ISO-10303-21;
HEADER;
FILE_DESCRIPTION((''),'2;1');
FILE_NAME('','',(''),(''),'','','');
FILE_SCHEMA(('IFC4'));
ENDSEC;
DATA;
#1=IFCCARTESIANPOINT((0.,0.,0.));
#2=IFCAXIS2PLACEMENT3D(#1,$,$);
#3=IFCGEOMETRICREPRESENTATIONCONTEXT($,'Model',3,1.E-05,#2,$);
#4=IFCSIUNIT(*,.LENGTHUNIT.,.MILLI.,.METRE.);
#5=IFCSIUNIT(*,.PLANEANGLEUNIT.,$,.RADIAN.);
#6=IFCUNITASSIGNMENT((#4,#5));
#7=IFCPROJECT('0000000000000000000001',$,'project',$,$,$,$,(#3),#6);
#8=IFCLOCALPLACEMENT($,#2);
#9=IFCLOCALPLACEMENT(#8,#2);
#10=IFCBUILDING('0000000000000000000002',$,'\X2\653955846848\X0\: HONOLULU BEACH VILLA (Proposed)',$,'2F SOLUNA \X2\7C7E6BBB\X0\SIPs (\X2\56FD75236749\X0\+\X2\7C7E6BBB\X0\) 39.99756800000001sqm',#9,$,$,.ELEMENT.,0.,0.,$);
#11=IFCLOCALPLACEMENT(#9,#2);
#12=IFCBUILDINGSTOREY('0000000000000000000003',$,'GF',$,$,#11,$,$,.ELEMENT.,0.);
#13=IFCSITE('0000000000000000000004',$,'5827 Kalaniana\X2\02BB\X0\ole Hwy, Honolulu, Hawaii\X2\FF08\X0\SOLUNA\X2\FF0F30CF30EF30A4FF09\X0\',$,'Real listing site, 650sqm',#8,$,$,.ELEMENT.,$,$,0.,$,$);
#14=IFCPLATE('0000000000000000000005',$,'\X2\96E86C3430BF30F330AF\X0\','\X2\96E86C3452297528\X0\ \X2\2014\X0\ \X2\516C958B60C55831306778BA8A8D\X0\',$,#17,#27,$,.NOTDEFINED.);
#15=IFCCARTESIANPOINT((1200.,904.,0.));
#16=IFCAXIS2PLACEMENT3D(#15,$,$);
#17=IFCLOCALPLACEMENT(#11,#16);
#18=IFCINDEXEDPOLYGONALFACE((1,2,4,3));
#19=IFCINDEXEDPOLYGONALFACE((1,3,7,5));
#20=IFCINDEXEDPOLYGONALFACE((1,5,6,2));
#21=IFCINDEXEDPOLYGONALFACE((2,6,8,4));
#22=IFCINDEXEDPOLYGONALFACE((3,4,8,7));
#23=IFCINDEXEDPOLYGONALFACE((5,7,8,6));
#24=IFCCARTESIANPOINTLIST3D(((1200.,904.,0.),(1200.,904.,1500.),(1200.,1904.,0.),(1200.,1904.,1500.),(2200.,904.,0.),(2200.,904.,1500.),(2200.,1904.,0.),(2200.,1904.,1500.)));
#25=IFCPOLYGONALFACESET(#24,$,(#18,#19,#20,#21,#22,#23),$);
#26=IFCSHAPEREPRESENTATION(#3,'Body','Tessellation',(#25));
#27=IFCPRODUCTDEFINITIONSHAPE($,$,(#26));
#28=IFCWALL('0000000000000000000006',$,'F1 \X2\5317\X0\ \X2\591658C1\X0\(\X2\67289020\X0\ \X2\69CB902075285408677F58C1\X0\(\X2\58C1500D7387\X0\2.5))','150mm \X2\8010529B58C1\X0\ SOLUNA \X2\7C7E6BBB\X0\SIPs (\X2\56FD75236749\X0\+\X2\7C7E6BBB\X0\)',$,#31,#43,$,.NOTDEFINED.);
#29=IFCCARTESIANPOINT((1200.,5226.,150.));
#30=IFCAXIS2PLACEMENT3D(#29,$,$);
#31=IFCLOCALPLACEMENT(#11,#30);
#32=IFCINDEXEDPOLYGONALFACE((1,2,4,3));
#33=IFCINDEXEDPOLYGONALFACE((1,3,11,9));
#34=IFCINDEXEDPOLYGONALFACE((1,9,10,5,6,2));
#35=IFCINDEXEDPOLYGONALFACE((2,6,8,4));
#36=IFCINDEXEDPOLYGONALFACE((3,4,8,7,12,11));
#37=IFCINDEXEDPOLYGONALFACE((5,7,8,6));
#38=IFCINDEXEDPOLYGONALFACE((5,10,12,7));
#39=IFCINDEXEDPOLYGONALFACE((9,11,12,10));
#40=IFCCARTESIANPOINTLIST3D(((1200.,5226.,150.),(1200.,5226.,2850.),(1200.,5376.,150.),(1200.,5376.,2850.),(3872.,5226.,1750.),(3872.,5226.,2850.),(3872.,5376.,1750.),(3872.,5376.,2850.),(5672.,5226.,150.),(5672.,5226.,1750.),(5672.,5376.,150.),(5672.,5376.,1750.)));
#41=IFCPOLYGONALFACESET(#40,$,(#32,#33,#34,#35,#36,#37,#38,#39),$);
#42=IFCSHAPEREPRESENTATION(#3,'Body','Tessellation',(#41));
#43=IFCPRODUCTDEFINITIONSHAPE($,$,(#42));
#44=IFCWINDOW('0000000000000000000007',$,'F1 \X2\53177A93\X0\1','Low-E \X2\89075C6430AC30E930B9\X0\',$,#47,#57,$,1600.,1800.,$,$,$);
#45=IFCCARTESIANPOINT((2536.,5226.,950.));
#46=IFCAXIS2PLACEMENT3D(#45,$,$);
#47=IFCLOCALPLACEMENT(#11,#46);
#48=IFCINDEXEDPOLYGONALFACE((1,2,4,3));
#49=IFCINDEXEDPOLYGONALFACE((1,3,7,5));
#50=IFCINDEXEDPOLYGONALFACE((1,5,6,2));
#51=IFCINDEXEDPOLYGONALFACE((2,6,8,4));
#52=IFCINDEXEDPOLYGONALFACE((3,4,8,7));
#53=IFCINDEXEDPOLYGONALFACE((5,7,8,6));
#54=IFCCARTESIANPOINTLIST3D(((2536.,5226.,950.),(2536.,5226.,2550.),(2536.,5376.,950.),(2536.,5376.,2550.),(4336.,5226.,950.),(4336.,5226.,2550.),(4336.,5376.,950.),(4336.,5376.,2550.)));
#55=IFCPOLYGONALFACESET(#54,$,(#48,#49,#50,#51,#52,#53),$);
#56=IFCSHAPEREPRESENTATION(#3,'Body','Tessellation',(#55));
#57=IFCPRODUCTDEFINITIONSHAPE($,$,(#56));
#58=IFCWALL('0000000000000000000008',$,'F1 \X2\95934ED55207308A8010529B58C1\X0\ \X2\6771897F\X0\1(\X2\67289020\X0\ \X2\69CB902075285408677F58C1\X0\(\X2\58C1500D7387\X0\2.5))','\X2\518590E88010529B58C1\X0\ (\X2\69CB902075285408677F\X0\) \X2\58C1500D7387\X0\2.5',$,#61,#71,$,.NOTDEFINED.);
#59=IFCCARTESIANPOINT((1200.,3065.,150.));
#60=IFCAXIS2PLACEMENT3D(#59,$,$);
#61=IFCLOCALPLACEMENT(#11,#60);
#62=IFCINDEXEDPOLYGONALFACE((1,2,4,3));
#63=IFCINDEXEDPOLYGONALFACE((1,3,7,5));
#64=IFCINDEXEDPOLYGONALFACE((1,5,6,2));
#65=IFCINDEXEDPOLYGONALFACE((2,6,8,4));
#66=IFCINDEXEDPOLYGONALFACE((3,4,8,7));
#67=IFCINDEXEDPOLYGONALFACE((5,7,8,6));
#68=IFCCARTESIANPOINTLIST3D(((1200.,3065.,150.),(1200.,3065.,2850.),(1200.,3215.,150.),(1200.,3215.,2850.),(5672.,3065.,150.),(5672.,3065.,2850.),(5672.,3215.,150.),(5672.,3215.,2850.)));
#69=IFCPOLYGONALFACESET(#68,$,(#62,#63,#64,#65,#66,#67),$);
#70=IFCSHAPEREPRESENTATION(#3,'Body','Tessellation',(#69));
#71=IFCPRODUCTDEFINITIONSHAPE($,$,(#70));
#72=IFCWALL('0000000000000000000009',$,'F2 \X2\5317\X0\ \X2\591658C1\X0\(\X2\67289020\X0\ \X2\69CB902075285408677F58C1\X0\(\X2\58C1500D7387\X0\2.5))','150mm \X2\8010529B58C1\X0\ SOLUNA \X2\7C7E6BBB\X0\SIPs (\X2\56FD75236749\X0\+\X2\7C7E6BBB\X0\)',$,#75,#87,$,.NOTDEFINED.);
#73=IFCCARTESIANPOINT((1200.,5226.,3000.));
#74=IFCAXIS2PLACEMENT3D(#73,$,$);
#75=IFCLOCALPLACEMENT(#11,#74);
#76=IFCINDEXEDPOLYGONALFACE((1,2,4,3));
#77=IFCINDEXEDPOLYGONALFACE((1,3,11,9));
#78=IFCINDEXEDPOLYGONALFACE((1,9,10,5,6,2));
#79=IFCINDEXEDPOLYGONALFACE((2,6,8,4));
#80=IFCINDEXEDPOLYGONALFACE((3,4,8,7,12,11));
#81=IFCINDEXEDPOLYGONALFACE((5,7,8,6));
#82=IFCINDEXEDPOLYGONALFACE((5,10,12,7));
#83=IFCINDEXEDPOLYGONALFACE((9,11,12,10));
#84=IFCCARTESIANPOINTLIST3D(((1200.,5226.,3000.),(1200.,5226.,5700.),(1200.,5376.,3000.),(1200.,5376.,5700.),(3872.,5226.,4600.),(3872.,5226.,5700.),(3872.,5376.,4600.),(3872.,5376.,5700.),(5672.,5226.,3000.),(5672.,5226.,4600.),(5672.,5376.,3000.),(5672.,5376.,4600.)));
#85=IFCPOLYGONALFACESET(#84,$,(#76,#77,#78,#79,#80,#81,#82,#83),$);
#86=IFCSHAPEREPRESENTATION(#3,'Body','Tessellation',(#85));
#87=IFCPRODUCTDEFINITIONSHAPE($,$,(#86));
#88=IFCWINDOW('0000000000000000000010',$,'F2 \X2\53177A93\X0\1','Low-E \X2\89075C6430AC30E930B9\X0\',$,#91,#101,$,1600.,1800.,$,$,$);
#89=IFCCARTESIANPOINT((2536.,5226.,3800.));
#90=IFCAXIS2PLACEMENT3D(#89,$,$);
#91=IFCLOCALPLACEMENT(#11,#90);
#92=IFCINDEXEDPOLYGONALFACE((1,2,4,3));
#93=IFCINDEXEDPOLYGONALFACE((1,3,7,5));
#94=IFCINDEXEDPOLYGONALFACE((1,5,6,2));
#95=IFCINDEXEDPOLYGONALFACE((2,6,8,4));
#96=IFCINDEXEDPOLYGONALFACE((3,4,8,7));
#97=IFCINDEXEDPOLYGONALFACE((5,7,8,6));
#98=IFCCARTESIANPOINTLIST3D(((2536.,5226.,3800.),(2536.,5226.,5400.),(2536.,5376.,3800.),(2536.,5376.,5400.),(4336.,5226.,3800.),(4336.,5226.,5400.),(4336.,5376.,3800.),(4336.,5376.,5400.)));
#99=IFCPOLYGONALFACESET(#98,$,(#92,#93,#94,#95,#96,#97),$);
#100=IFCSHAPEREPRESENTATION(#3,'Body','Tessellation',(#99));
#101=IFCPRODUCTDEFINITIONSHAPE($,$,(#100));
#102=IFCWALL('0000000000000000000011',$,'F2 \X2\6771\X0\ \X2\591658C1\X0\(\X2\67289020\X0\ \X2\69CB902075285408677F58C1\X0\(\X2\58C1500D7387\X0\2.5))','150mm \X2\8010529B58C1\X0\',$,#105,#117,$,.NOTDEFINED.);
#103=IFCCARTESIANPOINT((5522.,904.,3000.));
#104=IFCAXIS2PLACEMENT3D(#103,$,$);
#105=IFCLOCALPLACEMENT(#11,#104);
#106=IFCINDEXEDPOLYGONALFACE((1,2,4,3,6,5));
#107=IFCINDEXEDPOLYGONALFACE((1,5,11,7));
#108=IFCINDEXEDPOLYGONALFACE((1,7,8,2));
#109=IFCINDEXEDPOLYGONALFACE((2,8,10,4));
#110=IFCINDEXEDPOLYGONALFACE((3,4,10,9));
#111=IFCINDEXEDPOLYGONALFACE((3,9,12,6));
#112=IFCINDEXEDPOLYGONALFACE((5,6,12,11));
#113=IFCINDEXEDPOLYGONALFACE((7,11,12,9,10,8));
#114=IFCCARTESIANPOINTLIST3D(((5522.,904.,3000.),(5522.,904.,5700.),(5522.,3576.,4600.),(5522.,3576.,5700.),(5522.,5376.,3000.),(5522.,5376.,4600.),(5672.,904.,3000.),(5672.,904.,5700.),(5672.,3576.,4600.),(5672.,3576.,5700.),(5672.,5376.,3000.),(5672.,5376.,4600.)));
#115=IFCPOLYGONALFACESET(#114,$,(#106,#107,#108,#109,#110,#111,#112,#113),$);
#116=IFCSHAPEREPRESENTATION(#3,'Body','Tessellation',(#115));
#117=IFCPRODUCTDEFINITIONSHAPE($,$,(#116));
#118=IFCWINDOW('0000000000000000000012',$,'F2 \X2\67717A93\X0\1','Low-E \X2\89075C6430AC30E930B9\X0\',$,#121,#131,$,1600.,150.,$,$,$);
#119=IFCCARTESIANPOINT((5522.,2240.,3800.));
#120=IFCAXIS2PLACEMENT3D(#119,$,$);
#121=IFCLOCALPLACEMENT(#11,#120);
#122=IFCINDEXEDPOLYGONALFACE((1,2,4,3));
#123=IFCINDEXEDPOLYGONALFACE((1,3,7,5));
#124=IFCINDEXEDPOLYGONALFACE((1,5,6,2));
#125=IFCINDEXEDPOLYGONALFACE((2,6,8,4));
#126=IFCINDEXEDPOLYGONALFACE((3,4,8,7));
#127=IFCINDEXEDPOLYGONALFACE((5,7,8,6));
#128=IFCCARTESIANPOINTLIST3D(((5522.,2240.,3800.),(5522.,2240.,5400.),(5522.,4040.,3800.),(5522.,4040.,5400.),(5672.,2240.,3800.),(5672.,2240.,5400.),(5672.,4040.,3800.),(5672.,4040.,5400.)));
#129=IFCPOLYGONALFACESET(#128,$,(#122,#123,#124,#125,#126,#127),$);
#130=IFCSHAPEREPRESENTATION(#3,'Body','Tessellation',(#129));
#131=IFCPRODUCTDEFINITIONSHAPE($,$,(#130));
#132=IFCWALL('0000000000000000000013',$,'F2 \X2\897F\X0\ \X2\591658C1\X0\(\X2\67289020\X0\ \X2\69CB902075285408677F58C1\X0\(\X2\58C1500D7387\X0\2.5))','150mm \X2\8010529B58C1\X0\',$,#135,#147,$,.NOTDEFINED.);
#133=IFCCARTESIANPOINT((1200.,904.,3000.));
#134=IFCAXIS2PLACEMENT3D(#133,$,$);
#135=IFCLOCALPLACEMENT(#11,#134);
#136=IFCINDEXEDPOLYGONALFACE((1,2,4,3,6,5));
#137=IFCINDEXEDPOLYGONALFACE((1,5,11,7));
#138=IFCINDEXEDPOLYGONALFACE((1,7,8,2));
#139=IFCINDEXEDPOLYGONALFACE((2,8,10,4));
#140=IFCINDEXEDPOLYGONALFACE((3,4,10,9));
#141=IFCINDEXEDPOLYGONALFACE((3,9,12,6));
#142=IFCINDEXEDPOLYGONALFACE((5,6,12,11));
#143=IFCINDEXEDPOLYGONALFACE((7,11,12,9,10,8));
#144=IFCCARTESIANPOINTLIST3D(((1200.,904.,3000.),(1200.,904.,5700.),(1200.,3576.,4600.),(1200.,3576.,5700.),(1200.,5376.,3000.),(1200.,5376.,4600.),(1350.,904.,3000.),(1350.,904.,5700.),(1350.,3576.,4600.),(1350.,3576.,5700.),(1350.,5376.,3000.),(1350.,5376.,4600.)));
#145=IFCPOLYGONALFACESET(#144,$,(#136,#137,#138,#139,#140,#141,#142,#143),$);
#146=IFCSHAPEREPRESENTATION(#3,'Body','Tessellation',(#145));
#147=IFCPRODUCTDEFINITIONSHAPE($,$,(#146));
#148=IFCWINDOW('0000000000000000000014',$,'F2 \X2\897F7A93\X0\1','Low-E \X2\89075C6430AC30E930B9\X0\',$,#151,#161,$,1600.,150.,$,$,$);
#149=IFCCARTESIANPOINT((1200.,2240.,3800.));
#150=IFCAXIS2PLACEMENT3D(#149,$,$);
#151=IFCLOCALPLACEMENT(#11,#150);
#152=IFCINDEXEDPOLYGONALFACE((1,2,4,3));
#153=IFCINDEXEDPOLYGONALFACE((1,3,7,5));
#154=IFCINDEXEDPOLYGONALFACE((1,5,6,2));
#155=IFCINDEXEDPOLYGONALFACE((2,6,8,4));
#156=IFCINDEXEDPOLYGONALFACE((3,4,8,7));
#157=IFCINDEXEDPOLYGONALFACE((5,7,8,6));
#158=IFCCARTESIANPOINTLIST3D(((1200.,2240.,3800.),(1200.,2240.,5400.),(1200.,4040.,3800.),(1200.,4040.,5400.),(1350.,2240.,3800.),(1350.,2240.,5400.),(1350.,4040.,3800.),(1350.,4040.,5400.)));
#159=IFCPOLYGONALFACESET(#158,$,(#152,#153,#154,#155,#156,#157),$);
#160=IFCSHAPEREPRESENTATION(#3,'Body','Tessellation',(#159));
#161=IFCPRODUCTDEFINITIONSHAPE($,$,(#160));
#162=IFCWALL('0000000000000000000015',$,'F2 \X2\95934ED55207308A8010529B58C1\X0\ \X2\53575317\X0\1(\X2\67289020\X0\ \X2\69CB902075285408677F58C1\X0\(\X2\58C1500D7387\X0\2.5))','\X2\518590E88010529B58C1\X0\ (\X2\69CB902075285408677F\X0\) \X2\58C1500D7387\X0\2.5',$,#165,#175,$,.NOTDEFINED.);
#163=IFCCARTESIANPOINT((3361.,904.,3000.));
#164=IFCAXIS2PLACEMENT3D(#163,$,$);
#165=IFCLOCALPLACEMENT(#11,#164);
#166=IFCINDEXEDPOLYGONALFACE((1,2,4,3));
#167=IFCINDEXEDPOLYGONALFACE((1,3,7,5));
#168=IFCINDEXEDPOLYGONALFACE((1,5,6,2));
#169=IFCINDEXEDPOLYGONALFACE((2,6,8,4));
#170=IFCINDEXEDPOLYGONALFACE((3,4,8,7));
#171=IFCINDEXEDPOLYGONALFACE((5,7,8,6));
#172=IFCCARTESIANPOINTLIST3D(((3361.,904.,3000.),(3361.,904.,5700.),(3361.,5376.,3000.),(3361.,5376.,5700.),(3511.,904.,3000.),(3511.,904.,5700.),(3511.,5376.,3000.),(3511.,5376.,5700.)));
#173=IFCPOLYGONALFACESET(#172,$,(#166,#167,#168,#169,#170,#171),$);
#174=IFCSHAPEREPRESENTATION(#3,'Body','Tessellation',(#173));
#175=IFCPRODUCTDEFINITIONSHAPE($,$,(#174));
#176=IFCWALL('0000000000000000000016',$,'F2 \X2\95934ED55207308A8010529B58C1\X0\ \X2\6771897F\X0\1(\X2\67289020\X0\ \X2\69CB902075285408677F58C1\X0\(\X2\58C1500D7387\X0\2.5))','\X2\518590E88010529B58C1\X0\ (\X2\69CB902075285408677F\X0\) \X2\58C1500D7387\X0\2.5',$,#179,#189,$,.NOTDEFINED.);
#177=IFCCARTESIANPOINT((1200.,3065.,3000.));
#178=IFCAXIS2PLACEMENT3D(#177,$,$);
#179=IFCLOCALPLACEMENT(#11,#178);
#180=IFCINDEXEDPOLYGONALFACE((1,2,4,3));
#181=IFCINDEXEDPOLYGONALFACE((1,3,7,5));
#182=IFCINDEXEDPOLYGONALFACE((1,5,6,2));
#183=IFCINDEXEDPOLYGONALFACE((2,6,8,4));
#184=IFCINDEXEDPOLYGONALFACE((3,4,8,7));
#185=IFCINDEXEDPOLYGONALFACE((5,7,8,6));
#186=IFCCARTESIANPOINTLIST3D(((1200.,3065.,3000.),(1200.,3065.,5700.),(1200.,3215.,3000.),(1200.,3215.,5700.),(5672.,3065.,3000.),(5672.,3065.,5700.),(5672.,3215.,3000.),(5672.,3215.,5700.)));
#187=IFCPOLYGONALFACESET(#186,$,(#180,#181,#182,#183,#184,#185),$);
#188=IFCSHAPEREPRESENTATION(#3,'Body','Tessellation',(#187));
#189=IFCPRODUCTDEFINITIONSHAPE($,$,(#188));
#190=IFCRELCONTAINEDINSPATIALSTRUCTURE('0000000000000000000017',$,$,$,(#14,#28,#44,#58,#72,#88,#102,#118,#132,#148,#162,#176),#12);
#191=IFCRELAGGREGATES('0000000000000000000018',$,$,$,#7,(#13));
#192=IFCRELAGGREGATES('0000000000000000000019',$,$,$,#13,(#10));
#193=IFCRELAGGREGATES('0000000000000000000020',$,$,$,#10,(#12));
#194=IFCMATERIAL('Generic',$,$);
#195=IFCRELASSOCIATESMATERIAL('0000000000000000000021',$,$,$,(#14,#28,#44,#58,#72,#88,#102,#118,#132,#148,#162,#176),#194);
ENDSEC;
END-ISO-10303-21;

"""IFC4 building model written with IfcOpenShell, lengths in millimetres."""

from ifc_helpers import new_model, si_unit, frame, frame_2d, origin, place, context, project, spatial, rectangle, extrude, material, element, fill, save


model = new_model("IFC4")

# Units and contexts
model_context = context("Model", 3, precision=1e-05, world=origin())
ifc_project = project(units=[si_unit("LENGTHUNIT", "METRE", prefix="MILLI"), si_unit("PLANEANGLEUNIT", "RADIAN")], contexts=[model_context])

# Site, building, storey
site_placement = place(None, origin())
site = spatial("IfcSite", under=ifc_project, at=site_placement, Name="5827 Kalanianaʻole Hwy, Honolulu, Hawaii（SOLUNA／ハワイ）", ObjectType="Real listing site, 650sqm", CompositionType="ELEMENT", RefElevation=0.0)
building_placement = place(site_placement, origin())
building = spatial("IfcBuilding", under=site, at=building_placement, Name="改善案: HONOLULU BEACH VILLA (Proposed)", ObjectType="2F SOLUNA 籾殻SIPs (国産杉+籾殻) 39.99756800000001sqm", CompositionType="ELEMENT", ElevationOfRefHeight=0.0, ElevationOfTerrain=0.0)
storey_placement = place(building_placement, origin())
storey = spatial("IfcBuildingStorey", under=building, at=storey_placement, Name="GF", CompositionType="ELEMENT", Elevation=0.0)

# Plate
ifc_material_1 = material(Name="Generic")
plate_placement = place(storey_placement, frame((1200.0, 904.0, 0.0)))
element("IfcPlate", 1, at=plate_placement, inside=storey, material=ifc_material_1, Name="雨水タンク", Description="雨水利用 — 公開情報で確認", PredefinedType="NOTDEFINED", context=model_context, shape_type="SweptSolid", body=[
    extrude(rectangle(XDim=1000.0, YDim=1000.0, at=frame_2d((500.0, 500.0))), frame((1200.0, 904.0, 0.0)), (0.0, 0.0, 1.0), 1500.0),
])

# Wall, opening, window
wall_1_placement = place(storey_placement, frame((1200.0, 5226.0, 150.0)))
wall_1 = element("IfcWall", 2, at=wall_1_placement, inside=storey, material=ifc_material_1, Name="F1 北 外壁(木造 構造用合板壁(壁倍率2.5))", Description="150mm 耐力壁 SOLUNA 籾殻SIPs (国産杉+籾殻)", PredefinedType="NOTDEFINED", context=model_context, shape_type="SweptSolid", body=[
    extrude(rectangle(XDim=4472.0, YDim=150.0, at=frame_2d((2236.0, 75.0))), frame((1200.0, 5226.0, 150.0)), (0.0, 0.0, 1.0), 2700.0),
])
opening_1_placement = place(storey_placement, frame((2536.0, 5226.0, 950.0)))
opening_1 = element("IfcOpeningElement", 3, at=opening_1_placement, cuts=wall_1, PredefinedType="NOTDEFINED", context=model_context, shape_type="SweptSolid", body=[
    extrude(rectangle(XDim=1800.0, YDim=150.0, at=frame_2d((900.0, 75.0))), frame((2536.0, 5226.0, 950.0)), (0.0, 0.0, 1.0), 1600.0),
])
window_1_placement = place(storey_placement, frame((2536.0, 5226.0, 950.0)))
window_1 = element("IfcWindow", 4, at=window_1_placement, inside=storey, material=ifc_material_1, Name="F1 北窓1", Description="Low-E 複層ガラス", OverallHeight=1600.0, OverallWidth=1800.0, context=model_context, shape_type="SweptSolid", body=[
    extrude(rectangle(XDim=1800.0, YDim=150.0, at=frame_2d((900.0, 75.0))), frame((2536.0, 5226.0, 950.0)), (0.0, 0.0, 1.0), 1600.0),
])
fill(opening_1, window_1)

# Wall
wall_2_placement = place(storey_placement, frame((1200.0, 3065.0, 150.0)))
element("IfcWall", 5, at=wall_2_placement, inside=storey, material=ifc_material_1, Name="F1 間仕切り耐力壁 東西1(木造 構造用合板壁(壁倍率2.5))", Description="内部耐力壁 (構造用合板) 壁倍率2.5", PredefinedType="NOTDEFINED", context=model_context, shape_type="SweptSolid", body=[
    extrude(rectangle(XDim=4472.0, YDim=150.0, at=frame_2d((2236.0, 75.0))), frame((1200.0, 3065.0, 150.0)), (0.0, 0.0, 1.0), 2700.0),
])

# Walls, openings, windows
wall_3_placement = place(storey_placement, frame((1200.0, 5226.0, 3000.0)))
wall_3 = element("IfcWall", 6, at=wall_3_placement, inside=storey, material=ifc_material_1, Name="F2 北 外壁(木造 構造用合板壁(壁倍率2.5))", Description="150mm 耐力壁 SOLUNA 籾殻SIPs (国産杉+籾殻)", PredefinedType="NOTDEFINED", context=model_context, shape_type="SweptSolid", body=[
    extrude(rectangle(XDim=4472.0, YDim=150.0, at=frame_2d((2236.0, 75.0))), frame((1200.0, 5226.0, 3000.0)), (0.0, 0.0, 1.0), 2700.0),
])
opening_2_placement = place(storey_placement, frame((2536.0, 5226.0, 3800.0)))
opening_2 = element("IfcOpeningElement", 7, at=opening_2_placement, cuts=wall_3, PredefinedType="NOTDEFINED", context=model_context, shape_type="SweptSolid", body=[
    extrude(rectangle(XDim=1800.0, YDim=150.0, at=frame_2d((900.0, 75.0))), frame((2536.0, 5226.0, 3800.0)), (0.0, 0.0, 1.0), 1600.0),
])
window_2_placement = place(storey_placement, frame((2536.0, 5226.0, 3800.0)))
window_2 = element("IfcWindow", 8, at=window_2_placement, inside=storey, material=ifc_material_1, Name="F2 北窓1", Description="Low-E 複層ガラス", OverallHeight=1600.0, OverallWidth=1800.0, context=model_context, shape_type="SweptSolid", body=[
    extrude(rectangle(XDim=1800.0, YDim=150.0, at=frame_2d((900.0, 75.0))), frame((2536.0, 5226.0, 3800.0)), (0.0, 0.0, 1.0), 1600.0),
])
fill(opening_2, window_2)
wall_4_placement = place(storey_placement, frame((5522.0, 904.0, 3000.0)))
wall_4 = element("IfcWall", 9, at=wall_4_placement, inside=storey, material=ifc_material_1, Name="F2 東 外壁(木造 構造用合板壁(壁倍率2.5))", Description="150mm 耐力壁", PredefinedType="NOTDEFINED", context=model_context, shape_type="SweptSolid", body=[
    extrude(rectangle(XDim=150.0, YDim=4472.0, at=frame_2d((75.0, 2236.0))), frame((5522.0, 904.0, 3000.0)), (0.0, 0.0, 1.0), 2700.0),
])
opening_3_placement = place(storey_placement, frame((5522.0, 2240.0, 3800.0)))
opening_3 = element("IfcOpeningElement", 10, at=opening_3_placement, cuts=wall_4, PredefinedType="NOTDEFINED", context=model_context, shape_type="SweptSolid", body=[
    extrude(rectangle(XDim=150.0, YDim=1800.0, at=frame_2d((75.0, 900.0))), frame((5522.0, 2240.0, 3800.0)), (0.0, 0.0, 1.0), 1600.0),
])
window_3_placement = place(storey_placement, frame((5522.0, 2240.0, 3800.0)))
window_3 = element("IfcWindow", 11, at=window_3_placement, inside=storey, material=ifc_material_1, Name="F2 東窓1", Description="Low-E 複層ガラス", OverallHeight=1600.0, OverallWidth=150.0, context=model_context, shape_type="SweptSolid", body=[
    extrude(rectangle(XDim=150.0, YDim=1800.0, at=frame_2d((75.0, 900.0))), frame((5522.0, 2240.0, 3800.0)), (0.0, 0.0, 1.0), 1600.0),
])
fill(opening_3, window_3)
wall_5_placement = place(storey_placement, frame((1200.0, 904.0, 3000.0)))
wall_5 = element("IfcWall", 12, at=wall_5_placement, inside=storey, material=ifc_material_1, Name="F2 西 外壁(木造 構造用合板壁(壁倍率2.5))", Description="150mm 耐力壁", PredefinedType="NOTDEFINED", context=model_context, shape_type="SweptSolid", body=[
    extrude(rectangle(XDim=150.0, YDim=4472.0, at=frame_2d((75.0, 2236.0))), frame((1200.0, 904.0, 3000.0)), (0.0, 0.0, 1.0), 2700.0),
])
opening_4_placement = place(storey_placement, frame((1200.0, 2240.0, 3800.0)))
opening_4 = element("IfcOpeningElement", 13, at=opening_4_placement, cuts=wall_5, PredefinedType="NOTDEFINED", context=model_context, shape_type="SweptSolid", body=[
    extrude(rectangle(XDim=150.0, YDim=1800.0, at=frame_2d((75.0, 900.0))), frame((1200.0, 2240.0, 3800.0)), (0.0, 0.0, 1.0), 1600.0),
])
window_4_placement = place(storey_placement, frame((1200.0, 2240.0, 3800.0)))
window_4 = element("IfcWindow", 14, at=window_4_placement, inside=storey, material=ifc_material_1, Name="F2 西窓1", Description="Low-E 複層ガラス", OverallHeight=1600.0, OverallWidth=150.0, context=model_context, shape_type="SweptSolid", body=[
    extrude(rectangle(XDim=150.0, YDim=1800.0, at=frame_2d((75.0, 900.0))), frame((1200.0, 2240.0, 3800.0)), (0.0, 0.0, 1.0), 1600.0),
])
fill(opening_4, window_4)

# Walls
wall_6_placement = place(storey_placement, frame((3361.0, 904.0, 3000.0)))
element("IfcWall", 15, at=wall_6_placement, inside=storey, material=ifc_material_1, Name="F2 間仕切り耐力壁 南北1(木造 構造用合板壁(壁倍率2.5))", Description="内部耐力壁 (構造用合板) 壁倍率2.5", PredefinedType="NOTDEFINED", context=model_context, shape_type="SweptSolid", body=[
    extrude(rectangle(XDim=150.0, YDim=4472.0, at=frame_2d((75.0, 2236.0))), frame((3361.0, 904.0, 3000.0)), (0.0, 0.0, 1.0), 2700.0),
])
wall_7_placement = place(storey_placement, frame((1200.0, 3065.0, 3000.0)))
element("IfcWall", 16, at=wall_7_placement, inside=storey, material=ifc_material_1, Name="F2 間仕切り耐力壁 東西1(木造 構造用合板壁(壁倍率2.5))", Description="内部耐力壁 (構造用合板) 壁倍率2.5", PredefinedType="NOTDEFINED", context=model_context, shape_type="SweptSolid", body=[
    extrude(rectangle(XDim=4472.0, YDim=150.0, at=frame_2d((2236.0, 75.0))), frame((1200.0, 3065.0, 3000.0)), (0.0, 0.0, 1.0), 2700.0),
])

save(model, "model.ifc")
